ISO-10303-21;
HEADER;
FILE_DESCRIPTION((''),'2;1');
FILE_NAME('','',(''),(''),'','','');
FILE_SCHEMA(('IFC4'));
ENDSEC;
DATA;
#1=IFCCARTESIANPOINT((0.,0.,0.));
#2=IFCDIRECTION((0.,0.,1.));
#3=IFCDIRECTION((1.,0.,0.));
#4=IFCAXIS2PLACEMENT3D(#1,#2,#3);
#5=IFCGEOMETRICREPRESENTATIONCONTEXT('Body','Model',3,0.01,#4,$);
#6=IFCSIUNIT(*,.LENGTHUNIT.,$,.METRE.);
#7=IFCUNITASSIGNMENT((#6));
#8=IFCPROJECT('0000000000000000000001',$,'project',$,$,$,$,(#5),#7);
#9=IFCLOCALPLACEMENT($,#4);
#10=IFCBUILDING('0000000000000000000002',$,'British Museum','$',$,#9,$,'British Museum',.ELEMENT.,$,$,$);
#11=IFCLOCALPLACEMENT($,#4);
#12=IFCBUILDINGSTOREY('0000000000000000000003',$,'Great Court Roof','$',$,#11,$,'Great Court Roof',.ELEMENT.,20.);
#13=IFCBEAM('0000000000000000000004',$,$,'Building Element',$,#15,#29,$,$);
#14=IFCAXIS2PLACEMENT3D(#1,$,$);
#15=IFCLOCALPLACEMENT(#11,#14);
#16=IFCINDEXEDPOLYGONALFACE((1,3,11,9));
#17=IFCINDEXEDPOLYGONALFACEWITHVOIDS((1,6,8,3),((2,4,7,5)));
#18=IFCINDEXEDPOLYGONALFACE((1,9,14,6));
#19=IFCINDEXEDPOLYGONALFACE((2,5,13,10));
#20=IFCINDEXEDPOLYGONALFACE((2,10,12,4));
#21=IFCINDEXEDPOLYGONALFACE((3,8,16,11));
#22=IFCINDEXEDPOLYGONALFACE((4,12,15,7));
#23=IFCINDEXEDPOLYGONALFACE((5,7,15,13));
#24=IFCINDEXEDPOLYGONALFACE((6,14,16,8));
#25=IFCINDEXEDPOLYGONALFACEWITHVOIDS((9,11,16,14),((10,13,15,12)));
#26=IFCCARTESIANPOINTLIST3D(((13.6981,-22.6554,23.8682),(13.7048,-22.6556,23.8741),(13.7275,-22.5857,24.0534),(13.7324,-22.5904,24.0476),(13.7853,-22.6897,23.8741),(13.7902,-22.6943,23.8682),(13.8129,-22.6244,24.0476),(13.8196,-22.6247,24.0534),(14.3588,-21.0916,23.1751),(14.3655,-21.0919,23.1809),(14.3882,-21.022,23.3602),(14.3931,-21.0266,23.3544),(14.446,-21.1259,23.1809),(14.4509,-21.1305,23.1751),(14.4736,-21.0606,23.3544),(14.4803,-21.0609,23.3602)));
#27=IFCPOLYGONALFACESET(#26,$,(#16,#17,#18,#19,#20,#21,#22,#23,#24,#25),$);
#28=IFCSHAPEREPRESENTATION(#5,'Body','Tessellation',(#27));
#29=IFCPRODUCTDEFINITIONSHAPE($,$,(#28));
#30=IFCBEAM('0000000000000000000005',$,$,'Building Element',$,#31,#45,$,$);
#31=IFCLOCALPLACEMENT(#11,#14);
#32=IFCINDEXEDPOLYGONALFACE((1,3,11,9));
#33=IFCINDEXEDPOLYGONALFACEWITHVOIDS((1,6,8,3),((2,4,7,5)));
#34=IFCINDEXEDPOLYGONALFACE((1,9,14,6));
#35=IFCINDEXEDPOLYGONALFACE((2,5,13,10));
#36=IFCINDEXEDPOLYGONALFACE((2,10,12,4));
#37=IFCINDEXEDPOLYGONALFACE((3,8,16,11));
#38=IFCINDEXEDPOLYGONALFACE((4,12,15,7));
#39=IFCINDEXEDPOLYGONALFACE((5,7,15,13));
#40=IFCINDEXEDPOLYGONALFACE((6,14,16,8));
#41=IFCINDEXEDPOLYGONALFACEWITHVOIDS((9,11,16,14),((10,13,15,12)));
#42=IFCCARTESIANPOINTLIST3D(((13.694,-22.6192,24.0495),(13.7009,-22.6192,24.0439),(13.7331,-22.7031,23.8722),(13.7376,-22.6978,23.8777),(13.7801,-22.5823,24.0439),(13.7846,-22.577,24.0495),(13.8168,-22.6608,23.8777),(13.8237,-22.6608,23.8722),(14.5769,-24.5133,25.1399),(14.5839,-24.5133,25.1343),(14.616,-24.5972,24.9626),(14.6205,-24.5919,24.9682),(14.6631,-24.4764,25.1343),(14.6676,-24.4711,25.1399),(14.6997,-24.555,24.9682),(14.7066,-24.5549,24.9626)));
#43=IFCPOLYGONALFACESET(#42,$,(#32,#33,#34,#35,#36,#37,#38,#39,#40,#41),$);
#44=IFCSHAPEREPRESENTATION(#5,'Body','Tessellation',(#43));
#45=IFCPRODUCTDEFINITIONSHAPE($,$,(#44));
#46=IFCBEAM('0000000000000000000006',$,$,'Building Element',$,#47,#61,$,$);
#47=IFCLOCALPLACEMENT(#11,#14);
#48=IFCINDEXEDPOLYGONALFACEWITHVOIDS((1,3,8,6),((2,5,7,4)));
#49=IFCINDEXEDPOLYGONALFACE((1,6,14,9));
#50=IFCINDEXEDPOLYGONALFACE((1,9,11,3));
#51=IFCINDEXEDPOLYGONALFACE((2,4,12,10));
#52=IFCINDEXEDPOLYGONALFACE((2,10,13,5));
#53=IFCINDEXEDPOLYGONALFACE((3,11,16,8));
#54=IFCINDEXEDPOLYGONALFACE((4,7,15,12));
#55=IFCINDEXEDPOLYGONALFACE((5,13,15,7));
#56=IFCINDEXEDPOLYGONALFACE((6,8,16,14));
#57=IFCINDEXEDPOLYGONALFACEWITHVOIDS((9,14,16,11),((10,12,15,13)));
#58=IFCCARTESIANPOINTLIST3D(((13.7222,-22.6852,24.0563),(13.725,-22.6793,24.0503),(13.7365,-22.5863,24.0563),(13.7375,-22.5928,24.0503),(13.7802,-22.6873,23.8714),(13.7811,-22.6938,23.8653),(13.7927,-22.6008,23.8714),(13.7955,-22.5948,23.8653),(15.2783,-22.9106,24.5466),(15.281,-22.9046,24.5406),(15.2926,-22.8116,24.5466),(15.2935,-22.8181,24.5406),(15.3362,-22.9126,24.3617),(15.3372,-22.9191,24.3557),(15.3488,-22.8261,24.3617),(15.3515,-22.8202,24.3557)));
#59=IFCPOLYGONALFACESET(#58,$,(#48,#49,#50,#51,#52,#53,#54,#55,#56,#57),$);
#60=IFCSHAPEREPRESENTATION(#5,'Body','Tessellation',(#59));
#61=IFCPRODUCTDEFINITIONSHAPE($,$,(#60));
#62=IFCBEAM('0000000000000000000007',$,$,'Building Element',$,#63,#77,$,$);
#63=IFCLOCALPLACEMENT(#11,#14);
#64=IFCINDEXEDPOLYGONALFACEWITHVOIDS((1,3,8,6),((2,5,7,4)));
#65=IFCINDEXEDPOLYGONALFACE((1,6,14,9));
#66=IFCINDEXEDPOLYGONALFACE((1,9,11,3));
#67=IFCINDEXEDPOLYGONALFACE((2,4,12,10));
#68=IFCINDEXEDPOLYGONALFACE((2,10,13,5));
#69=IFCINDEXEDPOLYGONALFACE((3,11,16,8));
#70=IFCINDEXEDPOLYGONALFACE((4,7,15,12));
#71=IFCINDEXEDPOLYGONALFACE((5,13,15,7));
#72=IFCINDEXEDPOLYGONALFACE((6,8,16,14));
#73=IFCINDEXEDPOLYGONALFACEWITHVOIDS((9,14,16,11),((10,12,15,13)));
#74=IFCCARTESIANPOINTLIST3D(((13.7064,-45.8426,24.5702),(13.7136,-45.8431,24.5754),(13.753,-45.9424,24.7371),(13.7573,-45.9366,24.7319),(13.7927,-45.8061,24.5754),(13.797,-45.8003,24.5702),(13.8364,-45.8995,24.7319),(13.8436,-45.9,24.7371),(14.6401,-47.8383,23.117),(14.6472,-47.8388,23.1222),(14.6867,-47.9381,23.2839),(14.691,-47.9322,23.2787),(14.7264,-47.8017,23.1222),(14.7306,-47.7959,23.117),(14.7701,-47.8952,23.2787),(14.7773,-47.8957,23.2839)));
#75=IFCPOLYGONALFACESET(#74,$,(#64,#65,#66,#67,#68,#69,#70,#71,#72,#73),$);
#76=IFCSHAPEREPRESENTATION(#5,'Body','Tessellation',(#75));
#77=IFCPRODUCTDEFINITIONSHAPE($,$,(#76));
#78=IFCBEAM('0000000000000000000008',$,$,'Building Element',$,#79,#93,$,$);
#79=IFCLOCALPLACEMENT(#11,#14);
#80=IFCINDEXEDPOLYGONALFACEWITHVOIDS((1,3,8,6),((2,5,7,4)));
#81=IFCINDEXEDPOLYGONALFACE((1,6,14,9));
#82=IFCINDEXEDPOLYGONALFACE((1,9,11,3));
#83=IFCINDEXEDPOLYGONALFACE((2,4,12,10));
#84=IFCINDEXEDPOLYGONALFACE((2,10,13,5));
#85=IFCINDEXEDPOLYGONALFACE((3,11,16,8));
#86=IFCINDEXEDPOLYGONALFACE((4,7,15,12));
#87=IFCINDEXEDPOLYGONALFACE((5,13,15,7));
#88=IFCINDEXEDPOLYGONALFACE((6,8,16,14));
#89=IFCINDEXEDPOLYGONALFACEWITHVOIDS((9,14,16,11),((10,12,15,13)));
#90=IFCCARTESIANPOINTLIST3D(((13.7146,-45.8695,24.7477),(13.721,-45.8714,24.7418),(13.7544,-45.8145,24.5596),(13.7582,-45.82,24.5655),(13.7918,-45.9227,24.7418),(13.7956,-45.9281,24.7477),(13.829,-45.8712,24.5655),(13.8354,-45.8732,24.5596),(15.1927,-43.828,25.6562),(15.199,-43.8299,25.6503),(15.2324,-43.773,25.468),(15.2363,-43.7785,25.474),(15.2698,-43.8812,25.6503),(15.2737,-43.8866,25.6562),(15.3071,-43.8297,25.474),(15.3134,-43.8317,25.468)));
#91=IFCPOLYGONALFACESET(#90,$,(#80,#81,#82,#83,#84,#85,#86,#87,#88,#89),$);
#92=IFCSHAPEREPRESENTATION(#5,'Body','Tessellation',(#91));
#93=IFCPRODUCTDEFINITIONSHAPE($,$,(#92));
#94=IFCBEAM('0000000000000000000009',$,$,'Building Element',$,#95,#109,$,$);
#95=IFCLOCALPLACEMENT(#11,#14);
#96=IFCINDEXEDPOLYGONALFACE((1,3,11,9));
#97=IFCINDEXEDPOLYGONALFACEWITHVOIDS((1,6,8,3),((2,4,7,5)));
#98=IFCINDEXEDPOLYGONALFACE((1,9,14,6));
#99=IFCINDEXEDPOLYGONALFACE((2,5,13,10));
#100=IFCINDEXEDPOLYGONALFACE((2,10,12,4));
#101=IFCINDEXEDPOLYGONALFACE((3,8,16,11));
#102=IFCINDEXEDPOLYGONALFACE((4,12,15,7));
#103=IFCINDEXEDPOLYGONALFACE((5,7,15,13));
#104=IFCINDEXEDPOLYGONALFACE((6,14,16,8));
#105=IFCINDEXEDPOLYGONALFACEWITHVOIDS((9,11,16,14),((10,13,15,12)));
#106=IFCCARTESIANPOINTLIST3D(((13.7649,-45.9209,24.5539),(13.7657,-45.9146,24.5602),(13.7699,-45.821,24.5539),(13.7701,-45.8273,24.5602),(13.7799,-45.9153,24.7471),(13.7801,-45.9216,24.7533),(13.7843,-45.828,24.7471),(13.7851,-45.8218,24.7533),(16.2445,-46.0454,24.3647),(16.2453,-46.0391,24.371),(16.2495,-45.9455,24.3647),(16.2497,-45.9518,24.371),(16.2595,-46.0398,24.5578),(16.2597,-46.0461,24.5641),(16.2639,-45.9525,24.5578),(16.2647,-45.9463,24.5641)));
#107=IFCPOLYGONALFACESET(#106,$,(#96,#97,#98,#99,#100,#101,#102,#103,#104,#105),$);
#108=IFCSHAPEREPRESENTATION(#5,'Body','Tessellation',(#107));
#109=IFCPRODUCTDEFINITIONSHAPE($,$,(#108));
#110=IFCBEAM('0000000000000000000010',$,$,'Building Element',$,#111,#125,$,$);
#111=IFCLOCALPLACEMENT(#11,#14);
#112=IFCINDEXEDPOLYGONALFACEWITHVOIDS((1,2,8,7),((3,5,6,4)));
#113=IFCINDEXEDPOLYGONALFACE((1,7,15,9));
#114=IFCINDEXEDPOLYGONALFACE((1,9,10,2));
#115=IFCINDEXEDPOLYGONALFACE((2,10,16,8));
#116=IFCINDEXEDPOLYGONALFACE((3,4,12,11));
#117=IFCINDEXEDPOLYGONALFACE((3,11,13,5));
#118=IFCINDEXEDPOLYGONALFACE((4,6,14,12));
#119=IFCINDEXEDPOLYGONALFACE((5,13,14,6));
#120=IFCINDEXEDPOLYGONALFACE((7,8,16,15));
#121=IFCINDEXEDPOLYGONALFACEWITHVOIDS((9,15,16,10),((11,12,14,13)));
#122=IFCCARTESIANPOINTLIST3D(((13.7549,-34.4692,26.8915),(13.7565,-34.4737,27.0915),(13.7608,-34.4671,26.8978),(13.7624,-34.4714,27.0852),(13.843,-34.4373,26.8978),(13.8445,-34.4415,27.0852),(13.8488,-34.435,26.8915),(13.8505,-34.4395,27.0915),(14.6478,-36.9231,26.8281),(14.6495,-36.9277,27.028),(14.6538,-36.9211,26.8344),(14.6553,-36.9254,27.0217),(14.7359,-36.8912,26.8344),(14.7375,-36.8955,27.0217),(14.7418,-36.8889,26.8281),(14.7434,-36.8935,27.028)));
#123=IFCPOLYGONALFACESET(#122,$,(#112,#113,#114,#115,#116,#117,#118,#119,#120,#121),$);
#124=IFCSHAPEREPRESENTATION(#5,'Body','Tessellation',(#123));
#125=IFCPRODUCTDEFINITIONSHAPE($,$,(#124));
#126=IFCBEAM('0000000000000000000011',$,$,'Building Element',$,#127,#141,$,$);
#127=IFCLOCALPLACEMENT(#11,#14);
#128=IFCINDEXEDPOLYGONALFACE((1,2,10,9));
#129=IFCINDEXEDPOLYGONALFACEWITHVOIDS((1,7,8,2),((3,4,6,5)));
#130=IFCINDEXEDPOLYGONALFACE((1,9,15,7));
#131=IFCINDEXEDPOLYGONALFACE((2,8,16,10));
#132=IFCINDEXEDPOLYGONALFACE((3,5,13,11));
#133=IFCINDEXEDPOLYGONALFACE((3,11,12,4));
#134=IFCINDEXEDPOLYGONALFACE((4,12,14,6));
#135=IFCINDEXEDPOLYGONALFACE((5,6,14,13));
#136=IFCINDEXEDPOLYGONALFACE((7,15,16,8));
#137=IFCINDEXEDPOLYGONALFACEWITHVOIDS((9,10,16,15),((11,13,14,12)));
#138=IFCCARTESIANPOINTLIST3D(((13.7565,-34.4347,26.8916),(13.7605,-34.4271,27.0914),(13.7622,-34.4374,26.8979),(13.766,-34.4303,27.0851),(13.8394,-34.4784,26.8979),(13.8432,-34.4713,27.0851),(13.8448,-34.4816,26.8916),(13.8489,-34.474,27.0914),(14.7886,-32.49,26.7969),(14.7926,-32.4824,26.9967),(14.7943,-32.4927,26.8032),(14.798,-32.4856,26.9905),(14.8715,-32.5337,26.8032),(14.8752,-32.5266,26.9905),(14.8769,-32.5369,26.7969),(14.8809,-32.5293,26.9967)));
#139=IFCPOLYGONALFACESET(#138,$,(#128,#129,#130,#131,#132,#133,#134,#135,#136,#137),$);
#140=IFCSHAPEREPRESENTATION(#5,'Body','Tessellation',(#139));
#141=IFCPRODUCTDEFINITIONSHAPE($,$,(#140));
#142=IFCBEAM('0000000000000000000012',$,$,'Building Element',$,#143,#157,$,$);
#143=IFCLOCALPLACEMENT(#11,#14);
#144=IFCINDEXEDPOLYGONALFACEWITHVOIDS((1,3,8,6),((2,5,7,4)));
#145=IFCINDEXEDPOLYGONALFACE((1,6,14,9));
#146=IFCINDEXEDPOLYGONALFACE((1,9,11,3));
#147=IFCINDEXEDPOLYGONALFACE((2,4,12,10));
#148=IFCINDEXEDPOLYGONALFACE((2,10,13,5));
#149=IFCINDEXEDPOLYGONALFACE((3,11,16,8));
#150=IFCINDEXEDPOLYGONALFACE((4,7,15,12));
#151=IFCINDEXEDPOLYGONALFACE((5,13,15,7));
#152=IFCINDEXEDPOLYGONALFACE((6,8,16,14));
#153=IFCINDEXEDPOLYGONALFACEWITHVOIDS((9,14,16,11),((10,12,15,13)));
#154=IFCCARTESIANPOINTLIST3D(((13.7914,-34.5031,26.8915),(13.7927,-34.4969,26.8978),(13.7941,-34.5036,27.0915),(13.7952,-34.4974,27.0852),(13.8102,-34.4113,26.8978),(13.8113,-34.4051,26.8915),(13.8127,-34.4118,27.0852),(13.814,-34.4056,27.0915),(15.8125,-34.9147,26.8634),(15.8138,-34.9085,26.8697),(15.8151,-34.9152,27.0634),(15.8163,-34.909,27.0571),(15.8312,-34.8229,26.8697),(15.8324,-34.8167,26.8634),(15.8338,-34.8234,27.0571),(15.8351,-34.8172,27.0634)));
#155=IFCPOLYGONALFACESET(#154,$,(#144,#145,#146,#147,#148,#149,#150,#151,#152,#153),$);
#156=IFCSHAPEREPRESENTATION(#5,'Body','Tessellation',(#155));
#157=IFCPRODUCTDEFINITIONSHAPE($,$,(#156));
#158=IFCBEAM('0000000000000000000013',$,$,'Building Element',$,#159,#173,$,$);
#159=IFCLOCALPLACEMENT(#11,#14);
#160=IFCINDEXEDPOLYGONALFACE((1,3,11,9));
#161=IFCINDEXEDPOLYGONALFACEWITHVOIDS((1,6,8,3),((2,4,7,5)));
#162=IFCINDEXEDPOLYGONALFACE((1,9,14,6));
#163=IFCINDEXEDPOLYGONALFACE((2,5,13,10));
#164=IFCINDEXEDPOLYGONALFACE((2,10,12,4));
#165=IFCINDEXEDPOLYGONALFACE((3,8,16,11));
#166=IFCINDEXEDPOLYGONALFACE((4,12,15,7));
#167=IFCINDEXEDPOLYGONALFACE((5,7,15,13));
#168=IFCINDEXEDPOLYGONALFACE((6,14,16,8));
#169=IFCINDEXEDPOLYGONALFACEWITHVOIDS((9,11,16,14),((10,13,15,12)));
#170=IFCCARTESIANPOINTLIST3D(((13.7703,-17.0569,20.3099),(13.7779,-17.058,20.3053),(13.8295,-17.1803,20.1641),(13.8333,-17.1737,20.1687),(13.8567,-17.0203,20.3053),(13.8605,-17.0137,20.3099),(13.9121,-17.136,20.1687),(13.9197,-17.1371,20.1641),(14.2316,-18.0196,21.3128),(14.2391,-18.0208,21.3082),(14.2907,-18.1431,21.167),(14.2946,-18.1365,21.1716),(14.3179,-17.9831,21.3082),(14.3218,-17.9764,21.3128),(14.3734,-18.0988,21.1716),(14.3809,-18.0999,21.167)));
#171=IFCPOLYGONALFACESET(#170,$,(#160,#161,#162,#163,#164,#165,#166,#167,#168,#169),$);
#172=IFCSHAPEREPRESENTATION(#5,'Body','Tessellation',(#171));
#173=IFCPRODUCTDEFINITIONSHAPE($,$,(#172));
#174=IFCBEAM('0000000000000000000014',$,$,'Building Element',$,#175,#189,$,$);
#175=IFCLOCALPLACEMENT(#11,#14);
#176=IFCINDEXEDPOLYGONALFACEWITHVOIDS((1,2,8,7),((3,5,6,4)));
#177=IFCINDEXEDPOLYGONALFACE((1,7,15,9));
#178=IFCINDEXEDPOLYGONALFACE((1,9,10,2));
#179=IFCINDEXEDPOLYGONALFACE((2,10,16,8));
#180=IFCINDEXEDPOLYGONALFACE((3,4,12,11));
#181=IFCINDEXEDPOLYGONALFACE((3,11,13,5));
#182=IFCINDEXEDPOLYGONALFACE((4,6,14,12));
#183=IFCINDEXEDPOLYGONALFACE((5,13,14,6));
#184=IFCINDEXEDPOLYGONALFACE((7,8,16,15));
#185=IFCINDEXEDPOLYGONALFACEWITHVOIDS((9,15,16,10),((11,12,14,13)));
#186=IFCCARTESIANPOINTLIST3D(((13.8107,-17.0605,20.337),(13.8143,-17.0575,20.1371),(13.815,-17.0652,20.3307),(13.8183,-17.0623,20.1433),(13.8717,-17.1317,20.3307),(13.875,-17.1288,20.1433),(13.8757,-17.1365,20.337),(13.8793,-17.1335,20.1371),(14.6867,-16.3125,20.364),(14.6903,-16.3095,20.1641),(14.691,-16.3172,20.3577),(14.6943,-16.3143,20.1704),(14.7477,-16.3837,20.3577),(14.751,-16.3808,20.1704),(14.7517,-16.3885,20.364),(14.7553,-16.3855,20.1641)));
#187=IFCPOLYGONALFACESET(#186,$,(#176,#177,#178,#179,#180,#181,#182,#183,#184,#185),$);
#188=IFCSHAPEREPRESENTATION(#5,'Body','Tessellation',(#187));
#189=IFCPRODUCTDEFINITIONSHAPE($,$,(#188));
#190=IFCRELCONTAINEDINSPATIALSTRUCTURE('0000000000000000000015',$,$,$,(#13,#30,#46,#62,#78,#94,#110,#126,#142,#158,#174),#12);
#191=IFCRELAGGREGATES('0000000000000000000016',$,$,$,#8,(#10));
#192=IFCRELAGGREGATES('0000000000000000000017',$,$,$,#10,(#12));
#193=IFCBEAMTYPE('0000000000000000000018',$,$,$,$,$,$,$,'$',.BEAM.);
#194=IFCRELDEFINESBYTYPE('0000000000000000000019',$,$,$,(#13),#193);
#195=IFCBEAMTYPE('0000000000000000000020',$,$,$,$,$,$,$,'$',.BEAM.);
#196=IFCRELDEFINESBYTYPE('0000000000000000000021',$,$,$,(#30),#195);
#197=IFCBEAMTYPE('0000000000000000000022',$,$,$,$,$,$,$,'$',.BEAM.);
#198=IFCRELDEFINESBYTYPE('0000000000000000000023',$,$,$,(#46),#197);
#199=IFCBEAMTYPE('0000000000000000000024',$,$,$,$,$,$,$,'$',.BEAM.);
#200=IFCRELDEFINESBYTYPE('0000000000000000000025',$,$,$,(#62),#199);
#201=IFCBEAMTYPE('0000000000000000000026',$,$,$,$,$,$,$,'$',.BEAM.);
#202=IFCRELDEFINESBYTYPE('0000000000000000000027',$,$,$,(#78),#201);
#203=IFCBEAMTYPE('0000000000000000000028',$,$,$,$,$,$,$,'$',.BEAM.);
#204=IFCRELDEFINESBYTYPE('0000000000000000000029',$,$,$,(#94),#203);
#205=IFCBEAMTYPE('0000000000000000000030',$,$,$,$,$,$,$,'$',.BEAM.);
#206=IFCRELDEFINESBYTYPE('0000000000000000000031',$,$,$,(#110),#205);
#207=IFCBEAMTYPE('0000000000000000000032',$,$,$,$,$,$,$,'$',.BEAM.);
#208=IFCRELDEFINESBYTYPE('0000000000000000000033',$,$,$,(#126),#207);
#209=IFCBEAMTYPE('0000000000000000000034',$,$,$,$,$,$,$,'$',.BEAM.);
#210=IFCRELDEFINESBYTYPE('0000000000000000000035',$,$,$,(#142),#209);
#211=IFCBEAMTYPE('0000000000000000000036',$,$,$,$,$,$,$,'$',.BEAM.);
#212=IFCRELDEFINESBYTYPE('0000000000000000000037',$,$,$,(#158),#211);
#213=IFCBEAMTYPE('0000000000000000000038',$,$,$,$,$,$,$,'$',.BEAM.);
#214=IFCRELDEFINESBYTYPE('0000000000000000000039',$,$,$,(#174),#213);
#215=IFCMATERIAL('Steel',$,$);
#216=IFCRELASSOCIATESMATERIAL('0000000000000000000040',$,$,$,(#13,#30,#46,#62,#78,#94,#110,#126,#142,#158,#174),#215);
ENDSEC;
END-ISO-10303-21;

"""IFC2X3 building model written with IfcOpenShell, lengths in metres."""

from ifc_helpers import new_model, si_unit, frame, origin_with_axes, origin_2d, place, context, project, spatial, hollow_rectangle, extrude, material, type_object, element, save


model = new_model("IFC2X3")

# Units and contexts
model_context = context("Model", 3, precision=0.01, world=origin_with_axes(), identifier="Body")
ifc_project = project(units=[si_unit("LENGTHUNIT", "METRE")], contexts=[model_context])

# Building, storey
building_placement = place(None, origin_with_axes())
building = spatial("IfcBuilding", under=ifc_project, at=building_placement, Name="British Museum", Description="$", LongName="British Museum", CompositionType="ELEMENT")
storey_placement = place(None, origin_with_axes())
storey = spatial("IfcBuildingStorey", under=building, at=storey_placement, Name="Great Court Roof", Description="$", LongName="Great Court Roof", CompositionType="ELEMENT", Elevation=20.0)

# Beams
ifc_material = material(Name="Steel")
beam_type_1 = type_object("IfcBeamType", ElementType="$", PredefinedType="BEAM")
beam_1_placement = place(None, origin_with_axes())
element("IfcBeam", 1, at=beam_1_placement, inside=storey, type_object=beam_type_1, material=ifc_material, Description="Building Element", context=model_context, shape_type="SweptSolid", body=[
    extrude(hollow_rectangle(XDim=0.1, YDim=0.2, WallThickness=0.0063, InnerFilletRadius=-0.0063, OuterFilletRadius=0.0, at=origin_2d()), frame((13.7588, -22.64, 23.9608), z_axis=(0.360317, 0.852801, -0.378024), x_axis=(-0.921155, 0.389196, 0.0)), (0.0, 0.0, 1.0), 1.8337),
])
beam_type_2 = type_object("IfcBeamType", ElementType="$", PredefinedType="BEAM")
beam_2_placement = place(None, origin_with_axes())
element("IfcBeam", 2, at=beam_2_placement, inside=storey, type_object=beam_type_2, material=ifc_material, Description="Building Element", context=model_context, shape_type="SweptSolid", body=[
    extrude(hollow_rectangle(XDim=0.1, YDim=0.2, WallThickness=0.0063, InnerFilletRadius=-0.0063, OuterFilletRadius=0.0, at=origin_2d()), frame((13.7588, -22.64, 23.9608), z_axis=(0.374572, -0.803549, 0.462607), x_axis=(0.906364, 0.422498, 0.0)), (0.0, 0.0, 1.0), 2.3572),
])
beam_type_3 = type_object("IfcBeamType", ElementType="$", PredefinedType="BEAM")
beam_3_placement = place(None, origin_with_axes())
element("IfcBeam", 3, at=beam_3_placement, inside=storey, type_object=beam_type_3, material=ifc_material, Description="Building Element", context=model_context, shape_type="SweptSolid", body=[
    extrude(hollow_rectangle(XDim=0.1, YDim=0.2, WallThickness=0.0063, InnerFilletRadius=-0.0063, OuterFilletRadius=0.0, at=origin_2d()), frame((13.7588, -22.64, 23.9608), z_axis=(0.944796, -0.136839, 0.297716), x_axis=(0.143339, 0.989674, 0.0)), (0.0, 0.0, 1.0), 1.647),
])
beam_type_4 = type_object("IfcBeamType", ElementType="$", PredefinedType="BEAM")
beam_4_placement = place(None, origin_with_axes())
element("IfcBeam", 4, at=beam_4_placement, inside=storey, type_object=beam_type_4, material=ifc_material, Description="Building Element", context=model_context, shape_type="SweptSolid", body=[
    extrude(hollow_rectangle(XDim=0.1, YDim=0.2, WallThickness=0.0063, InnerFilletRadius=-0.0063, OuterFilletRadius=0.0, at=origin_2d()), frame((13.775, -45.8713, 24.6536), z_axis=(0.353753, -0.756121, -0.550582), x_axis=(0.905771, 0.423767, 0.0)), (0.0, 0.0, 1.0), 2.6394),
])
beam_type_5 = type_object("IfcBeamType", ElementType="$", PredefinedType="BEAM")
beam_5_placement = place(None, origin_with_axes())
element("IfcBeam", 5, at=beam_5_placement, inside=storey, type_object=beam_type_5, material=ifc_material, Description="Building Element", context=model_context, shape_type="SweptSolid", body=[
    extrude(hollow_rectangle(XDim=0.1, YDim=0.2, WallThickness=0.0063, InnerFilletRadius=-0.0063, OuterFilletRadius=0.0, at=origin_2d()), frame((13.775, -45.8713, 24.6536), z_axis=(0.551698, 0.762, 0.339096), x_axis=(-0.80999, 0.586444, 0.0)), (0.0, 0.0, 1.0), 2.6791),
])
beam_type_6 = type_object("IfcBeamType", ElementType="$", PredefinedType="BEAM")
beam_6_placement = place(None, origin_with_axes())
element("IfcBeam", 6, at=beam_6_placement, inside=storey, type_object=beam_type_6, material=ifc_material, Description="Building Element", context=model_context, shape_type="SweptSolid", body=[
    extrude(hollow_rectangle(XDim=0.1, YDim=0.2, WallThickness=0.0063, InnerFilletRadius=-0.0063, OuterFilletRadius=0.0, at=origin_2d()), frame((13.775, -45.8713, 24.6536), z_axis=(0.995854, -0.05, -0.075996), x_axis=(0.050145, 0.998742, 0.0)), (0.0, 0.0, 1.0), 2.4899),
])
beam_type_7 = type_object("IfcBeamType", ElementType="$", PredefinedType="BEAM")
beam_7_placement = place(None, origin_with_axes())
element("IfcBeam", 7, at=beam_7_placement, inside=storey, type_object=beam_type_7, material=ifc_material, Description="Building Element", context=model_context, shape_type="SweptSolid", body=[
    extrude(hollow_rectangle(XDim=0.1, YDim=0.2, WallThickness=0.0063, InnerFilletRadius=-0.0063, OuterFilletRadius=0.0, at=origin_2d()), frame((13.8027, -34.4543, 26.9915), z_axis=(0.341841, -0.939444, -0.024296), x_axis=(0.939721, 0.341942, 0.0)), (0.0, 0.0, 1.0), 2.6121),
])
beam_type_8 = type_object("IfcBeamType", ElementType="$", PredefinedType="BEAM")
beam_8_placement = place(None, origin_with_axes())
element("IfcBeam", 8, at=beam_8_placement, inside=storey, type_object=beam_type_8, material=ifc_material, Description="Building Element", context=model_context, shape_type="SweptSolid", body=[
    extrude(hollow_rectangle(XDim=0.1, YDim=0.2, WallThickness=0.0063, InnerFilletRadius=-0.0063, OuterFilletRadius=0.0, at=origin_2d()), frame((13.8027, -34.4543, 26.9915), z_axis=(0.46835, 0.882498, -0.042961), x_axis=(-0.883314, 0.468782, 0.0)), (0.0, 0.0, 1.0), 2.2036),
])
beam_type_9 = type_object("IfcBeamType", ElementType="$", PredefinedType="BEAM")
beam_9_placement = place(None, origin_with_axes())
element("IfcBeam", 9, at=beam_9_placement, inside=storey, type_object=beam_type_9, material=ifc_material, Description="Building Element", context=model_context, shape_type="SweptSolid", body=[
    extrude(hollow_rectangle(XDim=0.1, YDim=0.2, WallThickness=0.0063, InnerFilletRadius=-0.0063, OuterFilletRadius=0.0, at=origin_2d()), frame((13.8027, -34.4543, 26.9915), z_axis=(0.979796, -0.199532, -0.013647), x_axis=(0.199551, 0.979887, 0.0)), (0.0, 0.0, 1.0), 2.0628),
])
beam_type_10 = type_object("IfcBeamType", ElementType="$", PredefinedType="BEAM")
beam_10_placement = place(None, origin_with_axes())
element("IfcBeam", 10, at=beam_10_placement, inside=storey, type_object=beam_type_10, material=ifc_material, Description="Building Element", context=model_context, shape_type="SweptSolid", body=[
    extrude(hollow_rectangle(XDim=0.1, YDim=0.2, WallThickness=0.0063, InnerFilletRadius=-0.0063, OuterFilletRadius=0.0, at=origin_2d()), frame((13.845, -17.097, 20.237), z_axis=(0.314902, -0.657312, 0.684674), x_axis=(0.901848, 0.432053, 0.0)), (0.0, 0.0, 1.0), 1.4647),
])
beam_type_11 = type_object("IfcBeamType", ElementType="$", PredefinedType="BEAM")
beam_11_placement = place(None, origin_with_axes())
element("IfcBeam", 11, at=beam_11_placement, inside=storey, type_object=beam_type_11, material=ifc_material, Description="Building Element", context=model_context, shape_type="SweptSolid", body=[
    extrude(hollow_rectangle(XDim=0.1, YDim=0.2, WallThickness=0.0063, InnerFilletRadius=-0.0063, OuterFilletRadius=0.0, at=origin_2d()), frame((13.845, -17.097, 20.237), z_axis=(0.760272, 0.649181, 0.023463), x_axis=(-0.64936, 0.760481, 0.0)), (0.0, 0.0, 1.0), 1.1522),
])

save(model, "model.ifc")
